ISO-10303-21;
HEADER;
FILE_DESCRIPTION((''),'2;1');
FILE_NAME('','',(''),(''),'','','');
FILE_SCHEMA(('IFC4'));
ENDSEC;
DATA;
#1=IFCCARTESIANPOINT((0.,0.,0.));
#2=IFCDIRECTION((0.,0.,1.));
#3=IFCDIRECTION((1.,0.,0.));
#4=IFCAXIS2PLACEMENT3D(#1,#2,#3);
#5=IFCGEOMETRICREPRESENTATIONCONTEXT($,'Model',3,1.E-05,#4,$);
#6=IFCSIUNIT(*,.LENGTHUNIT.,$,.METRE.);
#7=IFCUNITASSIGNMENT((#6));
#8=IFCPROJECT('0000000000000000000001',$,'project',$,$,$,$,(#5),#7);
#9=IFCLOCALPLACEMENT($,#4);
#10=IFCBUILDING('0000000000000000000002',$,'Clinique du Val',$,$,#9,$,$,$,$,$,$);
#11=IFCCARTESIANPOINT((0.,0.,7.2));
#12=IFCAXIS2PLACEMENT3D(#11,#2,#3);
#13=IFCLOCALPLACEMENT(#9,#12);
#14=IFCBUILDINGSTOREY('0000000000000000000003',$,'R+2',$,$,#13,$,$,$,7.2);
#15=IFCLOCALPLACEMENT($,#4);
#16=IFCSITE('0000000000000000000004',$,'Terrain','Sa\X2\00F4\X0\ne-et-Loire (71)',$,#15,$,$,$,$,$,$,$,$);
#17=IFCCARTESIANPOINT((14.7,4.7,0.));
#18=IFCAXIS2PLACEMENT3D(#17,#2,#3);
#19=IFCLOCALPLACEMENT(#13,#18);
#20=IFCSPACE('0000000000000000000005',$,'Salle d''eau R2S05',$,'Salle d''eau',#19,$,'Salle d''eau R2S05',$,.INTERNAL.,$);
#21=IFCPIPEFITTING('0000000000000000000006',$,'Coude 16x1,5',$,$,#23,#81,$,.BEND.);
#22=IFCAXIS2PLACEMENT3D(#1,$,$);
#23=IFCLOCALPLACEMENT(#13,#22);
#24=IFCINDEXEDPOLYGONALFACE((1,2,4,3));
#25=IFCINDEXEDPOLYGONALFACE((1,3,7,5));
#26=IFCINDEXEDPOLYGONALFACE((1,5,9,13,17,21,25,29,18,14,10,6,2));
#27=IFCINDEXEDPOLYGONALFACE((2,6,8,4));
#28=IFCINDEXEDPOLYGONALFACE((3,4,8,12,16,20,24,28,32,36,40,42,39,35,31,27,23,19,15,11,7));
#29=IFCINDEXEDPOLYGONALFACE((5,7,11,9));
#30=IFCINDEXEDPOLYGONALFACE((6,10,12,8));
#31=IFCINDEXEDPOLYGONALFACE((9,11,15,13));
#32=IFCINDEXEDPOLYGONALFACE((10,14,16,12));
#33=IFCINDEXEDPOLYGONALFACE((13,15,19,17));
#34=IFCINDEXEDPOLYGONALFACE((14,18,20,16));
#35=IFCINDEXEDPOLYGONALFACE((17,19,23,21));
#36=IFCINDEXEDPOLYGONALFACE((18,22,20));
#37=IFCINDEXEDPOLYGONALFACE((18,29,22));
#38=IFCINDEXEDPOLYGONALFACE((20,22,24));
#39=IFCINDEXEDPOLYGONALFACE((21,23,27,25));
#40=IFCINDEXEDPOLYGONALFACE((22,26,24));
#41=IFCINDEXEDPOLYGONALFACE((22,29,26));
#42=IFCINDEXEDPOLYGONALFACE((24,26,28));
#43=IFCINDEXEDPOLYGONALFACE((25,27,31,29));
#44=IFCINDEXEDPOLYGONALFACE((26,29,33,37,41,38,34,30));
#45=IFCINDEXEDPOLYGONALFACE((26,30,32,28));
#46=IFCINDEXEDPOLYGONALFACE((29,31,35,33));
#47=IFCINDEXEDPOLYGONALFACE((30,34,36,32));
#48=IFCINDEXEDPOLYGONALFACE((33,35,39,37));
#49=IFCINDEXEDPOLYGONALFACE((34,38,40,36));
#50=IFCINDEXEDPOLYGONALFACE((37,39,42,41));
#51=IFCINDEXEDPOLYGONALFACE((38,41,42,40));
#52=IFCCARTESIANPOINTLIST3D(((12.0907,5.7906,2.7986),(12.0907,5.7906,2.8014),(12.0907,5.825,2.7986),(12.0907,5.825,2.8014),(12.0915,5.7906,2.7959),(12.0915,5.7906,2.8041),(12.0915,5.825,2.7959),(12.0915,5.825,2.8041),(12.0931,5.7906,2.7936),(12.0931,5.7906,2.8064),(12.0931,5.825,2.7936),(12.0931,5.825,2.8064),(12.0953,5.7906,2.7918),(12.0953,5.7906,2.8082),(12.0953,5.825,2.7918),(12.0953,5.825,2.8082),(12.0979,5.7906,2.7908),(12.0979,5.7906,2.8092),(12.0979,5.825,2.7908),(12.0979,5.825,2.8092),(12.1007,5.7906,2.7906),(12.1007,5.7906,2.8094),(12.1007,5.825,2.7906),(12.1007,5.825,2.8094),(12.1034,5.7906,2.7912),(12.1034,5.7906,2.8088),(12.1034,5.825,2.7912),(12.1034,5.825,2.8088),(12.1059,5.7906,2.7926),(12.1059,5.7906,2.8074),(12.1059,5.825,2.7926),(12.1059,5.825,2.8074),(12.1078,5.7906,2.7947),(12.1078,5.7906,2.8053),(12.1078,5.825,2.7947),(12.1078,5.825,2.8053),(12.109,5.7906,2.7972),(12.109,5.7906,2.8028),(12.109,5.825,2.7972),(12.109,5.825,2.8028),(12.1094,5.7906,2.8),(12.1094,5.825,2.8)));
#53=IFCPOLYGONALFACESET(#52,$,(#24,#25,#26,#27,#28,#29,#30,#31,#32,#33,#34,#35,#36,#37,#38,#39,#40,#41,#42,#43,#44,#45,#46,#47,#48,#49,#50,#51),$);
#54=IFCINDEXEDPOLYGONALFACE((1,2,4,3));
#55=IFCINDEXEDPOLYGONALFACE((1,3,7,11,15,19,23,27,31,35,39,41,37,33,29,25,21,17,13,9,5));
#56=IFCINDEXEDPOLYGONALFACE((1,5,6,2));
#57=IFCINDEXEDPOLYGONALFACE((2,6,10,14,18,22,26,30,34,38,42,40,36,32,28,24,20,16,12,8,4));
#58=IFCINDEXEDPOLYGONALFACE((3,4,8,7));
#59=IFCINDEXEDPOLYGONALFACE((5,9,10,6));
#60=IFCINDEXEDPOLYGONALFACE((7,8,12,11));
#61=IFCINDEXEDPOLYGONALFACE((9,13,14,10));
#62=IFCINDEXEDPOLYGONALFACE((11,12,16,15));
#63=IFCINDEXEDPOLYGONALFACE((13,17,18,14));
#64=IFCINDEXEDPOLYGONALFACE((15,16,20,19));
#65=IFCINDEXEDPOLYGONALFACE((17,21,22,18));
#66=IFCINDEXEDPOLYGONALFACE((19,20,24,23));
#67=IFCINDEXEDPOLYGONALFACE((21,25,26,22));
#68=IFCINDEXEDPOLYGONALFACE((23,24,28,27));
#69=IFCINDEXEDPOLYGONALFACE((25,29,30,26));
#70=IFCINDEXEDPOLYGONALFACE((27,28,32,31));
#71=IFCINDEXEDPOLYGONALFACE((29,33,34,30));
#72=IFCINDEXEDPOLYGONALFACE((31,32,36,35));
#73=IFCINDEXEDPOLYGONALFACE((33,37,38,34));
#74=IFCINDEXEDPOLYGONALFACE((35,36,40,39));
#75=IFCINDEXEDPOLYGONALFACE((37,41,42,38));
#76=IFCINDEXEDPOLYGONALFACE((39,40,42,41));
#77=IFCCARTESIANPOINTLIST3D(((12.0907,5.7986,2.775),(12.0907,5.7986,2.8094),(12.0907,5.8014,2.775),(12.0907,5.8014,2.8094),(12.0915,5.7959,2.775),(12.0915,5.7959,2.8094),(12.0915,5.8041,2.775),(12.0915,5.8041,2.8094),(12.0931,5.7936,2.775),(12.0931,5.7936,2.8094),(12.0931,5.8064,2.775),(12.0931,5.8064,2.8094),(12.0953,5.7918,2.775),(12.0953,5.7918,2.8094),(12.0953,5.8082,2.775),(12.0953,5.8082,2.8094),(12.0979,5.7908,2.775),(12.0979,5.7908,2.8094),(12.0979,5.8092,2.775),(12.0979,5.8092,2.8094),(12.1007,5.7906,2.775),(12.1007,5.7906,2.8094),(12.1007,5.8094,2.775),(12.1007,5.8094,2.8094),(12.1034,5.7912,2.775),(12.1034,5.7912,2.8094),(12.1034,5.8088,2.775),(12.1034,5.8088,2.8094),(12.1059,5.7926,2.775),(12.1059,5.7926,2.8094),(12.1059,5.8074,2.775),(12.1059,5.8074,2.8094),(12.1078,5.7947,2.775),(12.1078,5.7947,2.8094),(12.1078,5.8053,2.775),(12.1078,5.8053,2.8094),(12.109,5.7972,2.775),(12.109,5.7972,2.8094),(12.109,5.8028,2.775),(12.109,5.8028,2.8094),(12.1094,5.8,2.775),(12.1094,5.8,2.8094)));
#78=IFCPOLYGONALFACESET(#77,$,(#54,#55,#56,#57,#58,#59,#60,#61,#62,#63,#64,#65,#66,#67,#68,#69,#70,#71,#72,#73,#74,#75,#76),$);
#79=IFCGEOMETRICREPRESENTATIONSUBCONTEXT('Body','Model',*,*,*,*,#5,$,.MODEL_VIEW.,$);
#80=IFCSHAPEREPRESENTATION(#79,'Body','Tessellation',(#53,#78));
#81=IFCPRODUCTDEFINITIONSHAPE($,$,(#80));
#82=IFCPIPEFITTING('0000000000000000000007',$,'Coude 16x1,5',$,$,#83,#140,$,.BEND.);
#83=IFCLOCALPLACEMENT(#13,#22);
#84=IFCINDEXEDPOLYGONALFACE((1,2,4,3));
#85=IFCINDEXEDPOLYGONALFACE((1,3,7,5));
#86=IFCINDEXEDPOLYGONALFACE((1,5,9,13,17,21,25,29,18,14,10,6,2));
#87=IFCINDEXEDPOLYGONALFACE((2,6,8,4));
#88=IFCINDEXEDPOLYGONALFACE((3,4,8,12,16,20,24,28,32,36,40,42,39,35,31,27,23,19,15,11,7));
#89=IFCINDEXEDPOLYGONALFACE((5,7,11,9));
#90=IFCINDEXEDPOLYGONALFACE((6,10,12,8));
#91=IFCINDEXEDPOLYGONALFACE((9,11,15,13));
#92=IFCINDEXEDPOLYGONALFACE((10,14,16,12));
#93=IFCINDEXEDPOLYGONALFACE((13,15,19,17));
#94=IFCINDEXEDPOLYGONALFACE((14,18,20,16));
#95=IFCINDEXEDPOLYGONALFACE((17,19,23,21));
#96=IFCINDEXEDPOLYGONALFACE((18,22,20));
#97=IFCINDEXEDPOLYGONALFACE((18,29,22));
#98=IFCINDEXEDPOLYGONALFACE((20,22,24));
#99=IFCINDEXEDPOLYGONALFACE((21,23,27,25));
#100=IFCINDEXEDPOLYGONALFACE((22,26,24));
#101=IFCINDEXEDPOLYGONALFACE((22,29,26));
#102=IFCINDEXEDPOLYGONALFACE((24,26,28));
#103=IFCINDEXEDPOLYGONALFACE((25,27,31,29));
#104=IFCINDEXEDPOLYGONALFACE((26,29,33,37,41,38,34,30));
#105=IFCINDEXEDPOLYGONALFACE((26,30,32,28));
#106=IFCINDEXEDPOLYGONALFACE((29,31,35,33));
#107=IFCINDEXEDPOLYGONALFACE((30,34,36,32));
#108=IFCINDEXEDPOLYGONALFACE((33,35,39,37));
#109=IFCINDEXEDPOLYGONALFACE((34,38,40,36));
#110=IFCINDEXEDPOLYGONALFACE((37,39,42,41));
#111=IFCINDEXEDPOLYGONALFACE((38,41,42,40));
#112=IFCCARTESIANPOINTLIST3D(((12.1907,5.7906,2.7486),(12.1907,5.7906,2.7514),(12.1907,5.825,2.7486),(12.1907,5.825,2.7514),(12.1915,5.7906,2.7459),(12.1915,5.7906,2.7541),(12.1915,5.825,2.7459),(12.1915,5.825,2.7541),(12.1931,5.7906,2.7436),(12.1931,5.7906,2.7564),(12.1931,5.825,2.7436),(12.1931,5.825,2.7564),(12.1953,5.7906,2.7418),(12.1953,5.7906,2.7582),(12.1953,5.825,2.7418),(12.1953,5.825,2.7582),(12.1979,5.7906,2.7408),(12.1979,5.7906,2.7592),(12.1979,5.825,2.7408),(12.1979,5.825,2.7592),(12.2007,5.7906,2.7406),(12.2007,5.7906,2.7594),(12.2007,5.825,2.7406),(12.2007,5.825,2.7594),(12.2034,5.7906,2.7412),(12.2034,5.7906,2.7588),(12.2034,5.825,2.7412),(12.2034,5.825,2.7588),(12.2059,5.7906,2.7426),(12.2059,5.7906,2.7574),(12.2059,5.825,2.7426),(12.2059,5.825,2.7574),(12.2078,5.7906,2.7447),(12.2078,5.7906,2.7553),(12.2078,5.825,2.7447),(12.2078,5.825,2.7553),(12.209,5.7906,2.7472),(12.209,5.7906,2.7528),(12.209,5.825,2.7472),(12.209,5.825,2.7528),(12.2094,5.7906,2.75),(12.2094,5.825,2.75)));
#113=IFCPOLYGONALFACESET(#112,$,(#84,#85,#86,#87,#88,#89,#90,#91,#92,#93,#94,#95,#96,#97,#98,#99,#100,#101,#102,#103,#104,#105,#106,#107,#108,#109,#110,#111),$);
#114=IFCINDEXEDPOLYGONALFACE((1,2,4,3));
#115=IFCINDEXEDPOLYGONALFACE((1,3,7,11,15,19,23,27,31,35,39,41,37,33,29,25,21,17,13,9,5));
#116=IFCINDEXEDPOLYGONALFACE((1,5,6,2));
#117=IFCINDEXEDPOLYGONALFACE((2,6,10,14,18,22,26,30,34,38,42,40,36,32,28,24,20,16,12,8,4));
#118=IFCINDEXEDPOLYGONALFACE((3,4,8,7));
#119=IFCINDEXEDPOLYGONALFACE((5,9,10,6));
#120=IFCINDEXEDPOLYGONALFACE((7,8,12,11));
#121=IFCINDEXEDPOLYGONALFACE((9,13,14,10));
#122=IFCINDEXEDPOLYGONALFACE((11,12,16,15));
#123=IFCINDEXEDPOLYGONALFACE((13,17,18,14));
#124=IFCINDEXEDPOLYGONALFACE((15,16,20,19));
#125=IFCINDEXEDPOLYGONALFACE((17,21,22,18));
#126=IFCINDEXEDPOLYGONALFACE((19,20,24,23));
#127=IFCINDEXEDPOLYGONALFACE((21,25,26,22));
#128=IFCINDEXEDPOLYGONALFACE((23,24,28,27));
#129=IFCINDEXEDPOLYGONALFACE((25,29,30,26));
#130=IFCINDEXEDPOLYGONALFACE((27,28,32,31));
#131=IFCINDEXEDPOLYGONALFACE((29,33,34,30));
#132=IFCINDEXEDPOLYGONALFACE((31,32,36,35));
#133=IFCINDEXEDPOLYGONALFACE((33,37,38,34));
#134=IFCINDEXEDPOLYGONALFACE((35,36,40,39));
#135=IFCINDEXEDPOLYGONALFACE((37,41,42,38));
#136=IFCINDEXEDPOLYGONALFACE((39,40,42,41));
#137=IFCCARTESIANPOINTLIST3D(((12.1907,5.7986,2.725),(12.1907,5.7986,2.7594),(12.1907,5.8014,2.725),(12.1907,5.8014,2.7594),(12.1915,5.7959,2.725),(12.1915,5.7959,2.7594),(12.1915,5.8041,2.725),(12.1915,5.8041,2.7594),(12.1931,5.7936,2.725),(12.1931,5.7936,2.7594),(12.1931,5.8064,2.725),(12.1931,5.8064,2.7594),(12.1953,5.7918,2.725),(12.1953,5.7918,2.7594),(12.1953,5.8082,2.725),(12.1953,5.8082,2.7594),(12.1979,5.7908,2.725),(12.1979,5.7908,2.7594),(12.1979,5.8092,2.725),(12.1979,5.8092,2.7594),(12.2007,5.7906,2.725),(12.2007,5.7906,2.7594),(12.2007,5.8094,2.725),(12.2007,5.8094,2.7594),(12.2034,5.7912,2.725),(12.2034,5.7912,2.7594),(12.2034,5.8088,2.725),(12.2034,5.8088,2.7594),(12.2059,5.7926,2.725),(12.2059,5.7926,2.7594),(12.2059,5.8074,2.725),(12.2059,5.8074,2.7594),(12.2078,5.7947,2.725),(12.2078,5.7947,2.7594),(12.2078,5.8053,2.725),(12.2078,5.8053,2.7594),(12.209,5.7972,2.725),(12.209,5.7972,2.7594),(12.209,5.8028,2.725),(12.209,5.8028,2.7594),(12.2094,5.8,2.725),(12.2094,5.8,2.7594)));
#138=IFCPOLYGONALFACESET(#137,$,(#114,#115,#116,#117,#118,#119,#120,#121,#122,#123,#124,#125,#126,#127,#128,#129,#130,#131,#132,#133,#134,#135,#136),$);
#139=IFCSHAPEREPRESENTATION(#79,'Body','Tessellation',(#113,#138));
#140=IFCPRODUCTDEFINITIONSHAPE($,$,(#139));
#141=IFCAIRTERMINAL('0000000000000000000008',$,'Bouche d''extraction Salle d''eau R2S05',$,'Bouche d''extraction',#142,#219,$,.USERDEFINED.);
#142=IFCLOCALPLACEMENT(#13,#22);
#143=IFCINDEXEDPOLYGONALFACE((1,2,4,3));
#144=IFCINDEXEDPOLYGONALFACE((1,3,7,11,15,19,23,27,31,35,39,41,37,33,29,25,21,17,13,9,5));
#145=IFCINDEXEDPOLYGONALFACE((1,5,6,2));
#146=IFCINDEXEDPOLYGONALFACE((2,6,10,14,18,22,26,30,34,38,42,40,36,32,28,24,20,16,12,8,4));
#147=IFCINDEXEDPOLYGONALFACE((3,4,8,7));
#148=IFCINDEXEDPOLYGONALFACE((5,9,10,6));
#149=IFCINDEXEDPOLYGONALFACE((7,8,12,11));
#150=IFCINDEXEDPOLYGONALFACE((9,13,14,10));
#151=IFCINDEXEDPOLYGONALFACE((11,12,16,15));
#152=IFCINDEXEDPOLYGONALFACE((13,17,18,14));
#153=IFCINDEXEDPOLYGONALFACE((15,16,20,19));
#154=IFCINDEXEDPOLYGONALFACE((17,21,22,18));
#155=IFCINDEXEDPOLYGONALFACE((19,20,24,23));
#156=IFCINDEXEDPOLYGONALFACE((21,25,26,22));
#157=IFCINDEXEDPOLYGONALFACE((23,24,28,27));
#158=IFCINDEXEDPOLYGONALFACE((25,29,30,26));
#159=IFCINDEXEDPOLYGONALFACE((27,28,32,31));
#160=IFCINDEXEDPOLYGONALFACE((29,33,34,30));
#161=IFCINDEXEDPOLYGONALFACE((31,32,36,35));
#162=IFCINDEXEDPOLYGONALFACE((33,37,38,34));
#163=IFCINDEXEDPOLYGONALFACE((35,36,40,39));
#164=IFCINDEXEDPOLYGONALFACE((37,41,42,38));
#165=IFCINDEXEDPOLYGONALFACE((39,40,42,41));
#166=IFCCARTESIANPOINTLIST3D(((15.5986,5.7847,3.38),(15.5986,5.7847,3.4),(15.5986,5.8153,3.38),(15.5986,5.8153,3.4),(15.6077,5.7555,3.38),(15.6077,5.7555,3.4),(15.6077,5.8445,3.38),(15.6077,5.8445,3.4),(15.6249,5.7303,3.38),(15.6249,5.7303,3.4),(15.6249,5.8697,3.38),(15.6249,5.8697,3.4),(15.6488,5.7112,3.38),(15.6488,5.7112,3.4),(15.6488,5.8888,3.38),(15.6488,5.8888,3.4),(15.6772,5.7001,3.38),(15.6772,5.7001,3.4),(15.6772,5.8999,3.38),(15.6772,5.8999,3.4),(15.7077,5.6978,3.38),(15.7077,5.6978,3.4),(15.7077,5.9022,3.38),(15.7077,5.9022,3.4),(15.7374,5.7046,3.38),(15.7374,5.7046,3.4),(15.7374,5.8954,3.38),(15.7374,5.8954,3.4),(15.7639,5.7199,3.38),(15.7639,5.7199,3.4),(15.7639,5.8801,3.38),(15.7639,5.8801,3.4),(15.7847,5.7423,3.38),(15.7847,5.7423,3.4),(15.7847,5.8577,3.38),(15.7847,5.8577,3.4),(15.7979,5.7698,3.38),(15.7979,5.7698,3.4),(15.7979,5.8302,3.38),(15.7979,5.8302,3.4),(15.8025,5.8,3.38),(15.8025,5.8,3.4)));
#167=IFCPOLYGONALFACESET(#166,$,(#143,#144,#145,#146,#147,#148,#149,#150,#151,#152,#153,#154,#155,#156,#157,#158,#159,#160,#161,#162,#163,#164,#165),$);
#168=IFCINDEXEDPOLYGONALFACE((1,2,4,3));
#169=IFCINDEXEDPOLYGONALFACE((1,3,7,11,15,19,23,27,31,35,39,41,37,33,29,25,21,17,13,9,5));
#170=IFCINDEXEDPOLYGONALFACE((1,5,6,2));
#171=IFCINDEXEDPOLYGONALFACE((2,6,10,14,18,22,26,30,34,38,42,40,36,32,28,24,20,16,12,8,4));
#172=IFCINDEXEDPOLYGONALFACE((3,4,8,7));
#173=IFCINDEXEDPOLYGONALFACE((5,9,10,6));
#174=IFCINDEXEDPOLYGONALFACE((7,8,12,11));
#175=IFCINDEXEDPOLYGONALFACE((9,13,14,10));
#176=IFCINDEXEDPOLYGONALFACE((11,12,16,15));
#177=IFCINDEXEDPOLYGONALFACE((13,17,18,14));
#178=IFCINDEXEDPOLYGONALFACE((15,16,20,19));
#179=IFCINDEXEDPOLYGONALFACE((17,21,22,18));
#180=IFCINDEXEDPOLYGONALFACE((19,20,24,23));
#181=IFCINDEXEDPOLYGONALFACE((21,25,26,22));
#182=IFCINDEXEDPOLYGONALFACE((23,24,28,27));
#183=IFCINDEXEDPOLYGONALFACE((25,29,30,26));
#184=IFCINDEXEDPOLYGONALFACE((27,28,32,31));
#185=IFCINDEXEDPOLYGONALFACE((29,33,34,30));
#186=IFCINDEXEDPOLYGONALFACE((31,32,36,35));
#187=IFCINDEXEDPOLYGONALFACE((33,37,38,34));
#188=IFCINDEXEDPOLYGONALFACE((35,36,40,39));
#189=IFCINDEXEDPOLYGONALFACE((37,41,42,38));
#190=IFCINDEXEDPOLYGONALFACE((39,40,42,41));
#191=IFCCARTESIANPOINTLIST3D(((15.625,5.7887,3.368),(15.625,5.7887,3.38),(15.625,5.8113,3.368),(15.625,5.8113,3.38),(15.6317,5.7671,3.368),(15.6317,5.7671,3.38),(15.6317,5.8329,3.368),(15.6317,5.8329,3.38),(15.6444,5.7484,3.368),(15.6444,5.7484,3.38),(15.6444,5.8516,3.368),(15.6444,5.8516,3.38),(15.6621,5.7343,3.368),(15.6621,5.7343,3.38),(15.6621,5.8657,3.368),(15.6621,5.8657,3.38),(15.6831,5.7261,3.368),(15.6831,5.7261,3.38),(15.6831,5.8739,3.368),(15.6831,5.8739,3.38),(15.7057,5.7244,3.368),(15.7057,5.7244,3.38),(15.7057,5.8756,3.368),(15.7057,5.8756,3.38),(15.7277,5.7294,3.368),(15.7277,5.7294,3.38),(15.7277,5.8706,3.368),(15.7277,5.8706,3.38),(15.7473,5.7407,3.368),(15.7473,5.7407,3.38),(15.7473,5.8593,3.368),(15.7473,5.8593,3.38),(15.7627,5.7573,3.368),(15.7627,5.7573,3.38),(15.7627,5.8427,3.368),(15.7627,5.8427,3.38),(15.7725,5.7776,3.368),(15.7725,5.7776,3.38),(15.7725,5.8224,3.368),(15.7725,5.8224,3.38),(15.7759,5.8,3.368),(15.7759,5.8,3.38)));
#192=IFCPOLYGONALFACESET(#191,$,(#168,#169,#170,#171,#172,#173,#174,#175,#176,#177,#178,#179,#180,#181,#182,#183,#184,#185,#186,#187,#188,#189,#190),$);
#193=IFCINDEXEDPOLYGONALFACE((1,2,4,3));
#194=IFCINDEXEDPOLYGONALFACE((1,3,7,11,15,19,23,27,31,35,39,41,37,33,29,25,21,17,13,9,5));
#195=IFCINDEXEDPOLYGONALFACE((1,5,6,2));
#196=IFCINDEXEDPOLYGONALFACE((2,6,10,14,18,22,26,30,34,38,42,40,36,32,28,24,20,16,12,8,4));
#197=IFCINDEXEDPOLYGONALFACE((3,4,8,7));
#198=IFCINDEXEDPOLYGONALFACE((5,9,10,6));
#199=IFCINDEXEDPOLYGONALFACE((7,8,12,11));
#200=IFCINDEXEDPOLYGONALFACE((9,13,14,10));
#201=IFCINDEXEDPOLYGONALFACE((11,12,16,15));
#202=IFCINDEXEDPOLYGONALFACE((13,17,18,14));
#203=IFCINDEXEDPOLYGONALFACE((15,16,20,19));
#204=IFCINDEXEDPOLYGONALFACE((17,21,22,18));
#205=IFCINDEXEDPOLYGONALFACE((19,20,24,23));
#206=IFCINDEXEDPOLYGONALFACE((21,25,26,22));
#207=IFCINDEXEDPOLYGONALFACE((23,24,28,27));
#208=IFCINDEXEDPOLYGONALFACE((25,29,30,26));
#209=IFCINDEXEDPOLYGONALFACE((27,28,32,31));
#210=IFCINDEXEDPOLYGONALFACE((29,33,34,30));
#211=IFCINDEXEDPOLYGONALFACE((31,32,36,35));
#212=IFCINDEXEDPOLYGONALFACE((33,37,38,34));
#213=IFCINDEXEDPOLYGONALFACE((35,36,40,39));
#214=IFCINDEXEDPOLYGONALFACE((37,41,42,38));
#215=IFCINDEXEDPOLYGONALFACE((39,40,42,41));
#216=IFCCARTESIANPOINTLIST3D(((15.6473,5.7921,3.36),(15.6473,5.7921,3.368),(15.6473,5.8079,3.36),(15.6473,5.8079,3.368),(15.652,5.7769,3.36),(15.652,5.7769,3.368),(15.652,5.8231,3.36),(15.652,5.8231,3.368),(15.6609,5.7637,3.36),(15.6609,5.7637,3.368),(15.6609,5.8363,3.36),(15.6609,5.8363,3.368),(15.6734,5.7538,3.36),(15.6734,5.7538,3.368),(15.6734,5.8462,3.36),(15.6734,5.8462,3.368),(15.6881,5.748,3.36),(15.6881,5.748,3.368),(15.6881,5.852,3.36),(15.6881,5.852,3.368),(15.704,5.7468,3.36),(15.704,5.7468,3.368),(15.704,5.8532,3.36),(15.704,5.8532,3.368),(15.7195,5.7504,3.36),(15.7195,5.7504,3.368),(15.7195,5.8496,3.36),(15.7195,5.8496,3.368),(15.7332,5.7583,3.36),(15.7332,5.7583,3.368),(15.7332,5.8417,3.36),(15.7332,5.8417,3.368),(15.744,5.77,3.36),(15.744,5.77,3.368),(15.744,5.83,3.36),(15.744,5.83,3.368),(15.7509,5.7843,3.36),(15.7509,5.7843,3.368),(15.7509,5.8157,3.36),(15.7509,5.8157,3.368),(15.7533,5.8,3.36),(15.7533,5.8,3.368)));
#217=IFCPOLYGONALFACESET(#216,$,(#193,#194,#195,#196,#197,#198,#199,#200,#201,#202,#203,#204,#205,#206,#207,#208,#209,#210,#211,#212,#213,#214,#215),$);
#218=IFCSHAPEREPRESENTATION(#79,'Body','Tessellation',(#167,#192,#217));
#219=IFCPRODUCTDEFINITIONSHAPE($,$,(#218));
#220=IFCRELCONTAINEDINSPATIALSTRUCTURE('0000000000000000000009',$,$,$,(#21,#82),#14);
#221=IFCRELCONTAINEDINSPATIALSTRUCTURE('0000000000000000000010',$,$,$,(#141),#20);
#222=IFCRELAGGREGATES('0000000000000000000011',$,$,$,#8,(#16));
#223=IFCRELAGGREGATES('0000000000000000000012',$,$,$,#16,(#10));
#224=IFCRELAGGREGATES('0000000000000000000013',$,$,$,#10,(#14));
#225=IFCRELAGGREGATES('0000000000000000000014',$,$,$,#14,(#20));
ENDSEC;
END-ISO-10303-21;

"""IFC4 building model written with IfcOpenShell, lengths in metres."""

from ifc_helpers import new_model, si_unit, frame, origin_with_axes, place, context, subcontext, project, spatial, circle, extrude, element, save


model = new_model("IFC4")

# Units and contexts
model_context = context("Model", 3, precision=1e-05, world=origin_with_axes())
body_context = subcontext(model_context, "Body", "Model", "MODEL_VIEW")
ifc_project = project(units=[si_unit("LENGTHUNIT", "METRE")], contexts=[model_context])

# Site, building, storey
site_placement = place(None, origin_with_axes())
site = spatial("IfcSite", under=ifc_project, at=site_placement, Name="Terrain", Description="Saône-et-Loire (71)")
building_placement = place(None, origin_with_axes())
building = spatial("IfcBuilding", under=site, at=building_placement, Name="Clinique du Val")
storey_placement = place(building_placement, frame((0.0, 0.0, 7.2), z_axis=(0.0, 0.0, 1.0), x_axis=(1.0, 0.0, 0.0)))
storey = spatial("IfcBuildingStorey", under=building, at=storey_placement, Name="R+2", Elevation=7.2)

# Pipe fittings
for number, where, z_axis, x_axis, name in (
    (1, (12.1, 5.8, 2.8), (0.0, 0.0, 1.0), (1.0, 0.0, 0.0), "Coude 16x1,5"),
    (2, (12.2, 5.8, 2.75), (0.0, 0.0, 1.0), (1.0, 0.0, 0.0), "Coude 16x1,5"),
):
    element("IfcPipeFitting", number, at=place(storey_placement, frame(where, z_axis=z_axis, x_axis=x_axis)), inside=storey, Name=name, PredefinedType="BEND", context=body_context, shape_type="SweptSolid", body=[
        extrude(circle(Radius=0.0094), frame((0.0, -0.0094, 0.0), z_axis=(0.0, 1.0, 0.0), x_axis=(1.0, 0.0, 0.0)), (0.0, 0.0, 1.0), 0.0344),
        extrude(circle(Radius=0.0094), frame((0.0, 0.0, 0.0094), z_axis=(0.0, 0.0, -1.0), x_axis=(1.0, 0.0, 0.0)), (0.0, 0.0, 1.0), 0.0344),
    ])

# Shared definitions
space_1_placement = place(storey_placement, frame((14.7, 4.7, 0.0), z_axis=(0.0, 0.0, 1.0), x_axis=(1.0, 0.0, 0.0)))
space_1 = spatial("IfcSpace", under=storey, at=space_1_placement, Name="Salle d'eau R2S05", ObjectType="Salle d'eau", LongName="Salle d'eau R2S05", PredefinedType="INTERNAL")

# Air terminal
air_terminal_1_placement = place(space_1_placement, frame((1.0, 1.1, 3.36), z_axis=(0.0, 0.0, 1.0), x_axis=(1.0, 0.0, 0.0)))
element("IfcAirTerminal", 3, at=air_terminal_1_placement, inside=space_1, Name="Bouche d'extraction Salle d'eau R2S05", ObjectType="Bouche d'extraction", PredefinedType="USERDEFINED", context=body_context, shape_type="SweptSolid", body=[
    extrude(circle(Radius=0.1025), frame((0.0, 0.0, 0.02), z_axis=(0.0, 0.0, 1.0), x_axis=(1.0, 0.0, 0.0)), (0.0, 0.0, 1.0), 0.02),
    extrude(circle(Radius=0.0759), frame((0.0, 0.0, 0.008), z_axis=(0.0, 0.0, 1.0), x_axis=(1.0, 0.0, 0.0)), (0.0, 0.0, 1.0), 0.012),
    extrude(circle(Radius=0.0533), origin_with_axes(), (0.0, 0.0, 1.0), 0.008),
])

save(model, "model.ifc")
